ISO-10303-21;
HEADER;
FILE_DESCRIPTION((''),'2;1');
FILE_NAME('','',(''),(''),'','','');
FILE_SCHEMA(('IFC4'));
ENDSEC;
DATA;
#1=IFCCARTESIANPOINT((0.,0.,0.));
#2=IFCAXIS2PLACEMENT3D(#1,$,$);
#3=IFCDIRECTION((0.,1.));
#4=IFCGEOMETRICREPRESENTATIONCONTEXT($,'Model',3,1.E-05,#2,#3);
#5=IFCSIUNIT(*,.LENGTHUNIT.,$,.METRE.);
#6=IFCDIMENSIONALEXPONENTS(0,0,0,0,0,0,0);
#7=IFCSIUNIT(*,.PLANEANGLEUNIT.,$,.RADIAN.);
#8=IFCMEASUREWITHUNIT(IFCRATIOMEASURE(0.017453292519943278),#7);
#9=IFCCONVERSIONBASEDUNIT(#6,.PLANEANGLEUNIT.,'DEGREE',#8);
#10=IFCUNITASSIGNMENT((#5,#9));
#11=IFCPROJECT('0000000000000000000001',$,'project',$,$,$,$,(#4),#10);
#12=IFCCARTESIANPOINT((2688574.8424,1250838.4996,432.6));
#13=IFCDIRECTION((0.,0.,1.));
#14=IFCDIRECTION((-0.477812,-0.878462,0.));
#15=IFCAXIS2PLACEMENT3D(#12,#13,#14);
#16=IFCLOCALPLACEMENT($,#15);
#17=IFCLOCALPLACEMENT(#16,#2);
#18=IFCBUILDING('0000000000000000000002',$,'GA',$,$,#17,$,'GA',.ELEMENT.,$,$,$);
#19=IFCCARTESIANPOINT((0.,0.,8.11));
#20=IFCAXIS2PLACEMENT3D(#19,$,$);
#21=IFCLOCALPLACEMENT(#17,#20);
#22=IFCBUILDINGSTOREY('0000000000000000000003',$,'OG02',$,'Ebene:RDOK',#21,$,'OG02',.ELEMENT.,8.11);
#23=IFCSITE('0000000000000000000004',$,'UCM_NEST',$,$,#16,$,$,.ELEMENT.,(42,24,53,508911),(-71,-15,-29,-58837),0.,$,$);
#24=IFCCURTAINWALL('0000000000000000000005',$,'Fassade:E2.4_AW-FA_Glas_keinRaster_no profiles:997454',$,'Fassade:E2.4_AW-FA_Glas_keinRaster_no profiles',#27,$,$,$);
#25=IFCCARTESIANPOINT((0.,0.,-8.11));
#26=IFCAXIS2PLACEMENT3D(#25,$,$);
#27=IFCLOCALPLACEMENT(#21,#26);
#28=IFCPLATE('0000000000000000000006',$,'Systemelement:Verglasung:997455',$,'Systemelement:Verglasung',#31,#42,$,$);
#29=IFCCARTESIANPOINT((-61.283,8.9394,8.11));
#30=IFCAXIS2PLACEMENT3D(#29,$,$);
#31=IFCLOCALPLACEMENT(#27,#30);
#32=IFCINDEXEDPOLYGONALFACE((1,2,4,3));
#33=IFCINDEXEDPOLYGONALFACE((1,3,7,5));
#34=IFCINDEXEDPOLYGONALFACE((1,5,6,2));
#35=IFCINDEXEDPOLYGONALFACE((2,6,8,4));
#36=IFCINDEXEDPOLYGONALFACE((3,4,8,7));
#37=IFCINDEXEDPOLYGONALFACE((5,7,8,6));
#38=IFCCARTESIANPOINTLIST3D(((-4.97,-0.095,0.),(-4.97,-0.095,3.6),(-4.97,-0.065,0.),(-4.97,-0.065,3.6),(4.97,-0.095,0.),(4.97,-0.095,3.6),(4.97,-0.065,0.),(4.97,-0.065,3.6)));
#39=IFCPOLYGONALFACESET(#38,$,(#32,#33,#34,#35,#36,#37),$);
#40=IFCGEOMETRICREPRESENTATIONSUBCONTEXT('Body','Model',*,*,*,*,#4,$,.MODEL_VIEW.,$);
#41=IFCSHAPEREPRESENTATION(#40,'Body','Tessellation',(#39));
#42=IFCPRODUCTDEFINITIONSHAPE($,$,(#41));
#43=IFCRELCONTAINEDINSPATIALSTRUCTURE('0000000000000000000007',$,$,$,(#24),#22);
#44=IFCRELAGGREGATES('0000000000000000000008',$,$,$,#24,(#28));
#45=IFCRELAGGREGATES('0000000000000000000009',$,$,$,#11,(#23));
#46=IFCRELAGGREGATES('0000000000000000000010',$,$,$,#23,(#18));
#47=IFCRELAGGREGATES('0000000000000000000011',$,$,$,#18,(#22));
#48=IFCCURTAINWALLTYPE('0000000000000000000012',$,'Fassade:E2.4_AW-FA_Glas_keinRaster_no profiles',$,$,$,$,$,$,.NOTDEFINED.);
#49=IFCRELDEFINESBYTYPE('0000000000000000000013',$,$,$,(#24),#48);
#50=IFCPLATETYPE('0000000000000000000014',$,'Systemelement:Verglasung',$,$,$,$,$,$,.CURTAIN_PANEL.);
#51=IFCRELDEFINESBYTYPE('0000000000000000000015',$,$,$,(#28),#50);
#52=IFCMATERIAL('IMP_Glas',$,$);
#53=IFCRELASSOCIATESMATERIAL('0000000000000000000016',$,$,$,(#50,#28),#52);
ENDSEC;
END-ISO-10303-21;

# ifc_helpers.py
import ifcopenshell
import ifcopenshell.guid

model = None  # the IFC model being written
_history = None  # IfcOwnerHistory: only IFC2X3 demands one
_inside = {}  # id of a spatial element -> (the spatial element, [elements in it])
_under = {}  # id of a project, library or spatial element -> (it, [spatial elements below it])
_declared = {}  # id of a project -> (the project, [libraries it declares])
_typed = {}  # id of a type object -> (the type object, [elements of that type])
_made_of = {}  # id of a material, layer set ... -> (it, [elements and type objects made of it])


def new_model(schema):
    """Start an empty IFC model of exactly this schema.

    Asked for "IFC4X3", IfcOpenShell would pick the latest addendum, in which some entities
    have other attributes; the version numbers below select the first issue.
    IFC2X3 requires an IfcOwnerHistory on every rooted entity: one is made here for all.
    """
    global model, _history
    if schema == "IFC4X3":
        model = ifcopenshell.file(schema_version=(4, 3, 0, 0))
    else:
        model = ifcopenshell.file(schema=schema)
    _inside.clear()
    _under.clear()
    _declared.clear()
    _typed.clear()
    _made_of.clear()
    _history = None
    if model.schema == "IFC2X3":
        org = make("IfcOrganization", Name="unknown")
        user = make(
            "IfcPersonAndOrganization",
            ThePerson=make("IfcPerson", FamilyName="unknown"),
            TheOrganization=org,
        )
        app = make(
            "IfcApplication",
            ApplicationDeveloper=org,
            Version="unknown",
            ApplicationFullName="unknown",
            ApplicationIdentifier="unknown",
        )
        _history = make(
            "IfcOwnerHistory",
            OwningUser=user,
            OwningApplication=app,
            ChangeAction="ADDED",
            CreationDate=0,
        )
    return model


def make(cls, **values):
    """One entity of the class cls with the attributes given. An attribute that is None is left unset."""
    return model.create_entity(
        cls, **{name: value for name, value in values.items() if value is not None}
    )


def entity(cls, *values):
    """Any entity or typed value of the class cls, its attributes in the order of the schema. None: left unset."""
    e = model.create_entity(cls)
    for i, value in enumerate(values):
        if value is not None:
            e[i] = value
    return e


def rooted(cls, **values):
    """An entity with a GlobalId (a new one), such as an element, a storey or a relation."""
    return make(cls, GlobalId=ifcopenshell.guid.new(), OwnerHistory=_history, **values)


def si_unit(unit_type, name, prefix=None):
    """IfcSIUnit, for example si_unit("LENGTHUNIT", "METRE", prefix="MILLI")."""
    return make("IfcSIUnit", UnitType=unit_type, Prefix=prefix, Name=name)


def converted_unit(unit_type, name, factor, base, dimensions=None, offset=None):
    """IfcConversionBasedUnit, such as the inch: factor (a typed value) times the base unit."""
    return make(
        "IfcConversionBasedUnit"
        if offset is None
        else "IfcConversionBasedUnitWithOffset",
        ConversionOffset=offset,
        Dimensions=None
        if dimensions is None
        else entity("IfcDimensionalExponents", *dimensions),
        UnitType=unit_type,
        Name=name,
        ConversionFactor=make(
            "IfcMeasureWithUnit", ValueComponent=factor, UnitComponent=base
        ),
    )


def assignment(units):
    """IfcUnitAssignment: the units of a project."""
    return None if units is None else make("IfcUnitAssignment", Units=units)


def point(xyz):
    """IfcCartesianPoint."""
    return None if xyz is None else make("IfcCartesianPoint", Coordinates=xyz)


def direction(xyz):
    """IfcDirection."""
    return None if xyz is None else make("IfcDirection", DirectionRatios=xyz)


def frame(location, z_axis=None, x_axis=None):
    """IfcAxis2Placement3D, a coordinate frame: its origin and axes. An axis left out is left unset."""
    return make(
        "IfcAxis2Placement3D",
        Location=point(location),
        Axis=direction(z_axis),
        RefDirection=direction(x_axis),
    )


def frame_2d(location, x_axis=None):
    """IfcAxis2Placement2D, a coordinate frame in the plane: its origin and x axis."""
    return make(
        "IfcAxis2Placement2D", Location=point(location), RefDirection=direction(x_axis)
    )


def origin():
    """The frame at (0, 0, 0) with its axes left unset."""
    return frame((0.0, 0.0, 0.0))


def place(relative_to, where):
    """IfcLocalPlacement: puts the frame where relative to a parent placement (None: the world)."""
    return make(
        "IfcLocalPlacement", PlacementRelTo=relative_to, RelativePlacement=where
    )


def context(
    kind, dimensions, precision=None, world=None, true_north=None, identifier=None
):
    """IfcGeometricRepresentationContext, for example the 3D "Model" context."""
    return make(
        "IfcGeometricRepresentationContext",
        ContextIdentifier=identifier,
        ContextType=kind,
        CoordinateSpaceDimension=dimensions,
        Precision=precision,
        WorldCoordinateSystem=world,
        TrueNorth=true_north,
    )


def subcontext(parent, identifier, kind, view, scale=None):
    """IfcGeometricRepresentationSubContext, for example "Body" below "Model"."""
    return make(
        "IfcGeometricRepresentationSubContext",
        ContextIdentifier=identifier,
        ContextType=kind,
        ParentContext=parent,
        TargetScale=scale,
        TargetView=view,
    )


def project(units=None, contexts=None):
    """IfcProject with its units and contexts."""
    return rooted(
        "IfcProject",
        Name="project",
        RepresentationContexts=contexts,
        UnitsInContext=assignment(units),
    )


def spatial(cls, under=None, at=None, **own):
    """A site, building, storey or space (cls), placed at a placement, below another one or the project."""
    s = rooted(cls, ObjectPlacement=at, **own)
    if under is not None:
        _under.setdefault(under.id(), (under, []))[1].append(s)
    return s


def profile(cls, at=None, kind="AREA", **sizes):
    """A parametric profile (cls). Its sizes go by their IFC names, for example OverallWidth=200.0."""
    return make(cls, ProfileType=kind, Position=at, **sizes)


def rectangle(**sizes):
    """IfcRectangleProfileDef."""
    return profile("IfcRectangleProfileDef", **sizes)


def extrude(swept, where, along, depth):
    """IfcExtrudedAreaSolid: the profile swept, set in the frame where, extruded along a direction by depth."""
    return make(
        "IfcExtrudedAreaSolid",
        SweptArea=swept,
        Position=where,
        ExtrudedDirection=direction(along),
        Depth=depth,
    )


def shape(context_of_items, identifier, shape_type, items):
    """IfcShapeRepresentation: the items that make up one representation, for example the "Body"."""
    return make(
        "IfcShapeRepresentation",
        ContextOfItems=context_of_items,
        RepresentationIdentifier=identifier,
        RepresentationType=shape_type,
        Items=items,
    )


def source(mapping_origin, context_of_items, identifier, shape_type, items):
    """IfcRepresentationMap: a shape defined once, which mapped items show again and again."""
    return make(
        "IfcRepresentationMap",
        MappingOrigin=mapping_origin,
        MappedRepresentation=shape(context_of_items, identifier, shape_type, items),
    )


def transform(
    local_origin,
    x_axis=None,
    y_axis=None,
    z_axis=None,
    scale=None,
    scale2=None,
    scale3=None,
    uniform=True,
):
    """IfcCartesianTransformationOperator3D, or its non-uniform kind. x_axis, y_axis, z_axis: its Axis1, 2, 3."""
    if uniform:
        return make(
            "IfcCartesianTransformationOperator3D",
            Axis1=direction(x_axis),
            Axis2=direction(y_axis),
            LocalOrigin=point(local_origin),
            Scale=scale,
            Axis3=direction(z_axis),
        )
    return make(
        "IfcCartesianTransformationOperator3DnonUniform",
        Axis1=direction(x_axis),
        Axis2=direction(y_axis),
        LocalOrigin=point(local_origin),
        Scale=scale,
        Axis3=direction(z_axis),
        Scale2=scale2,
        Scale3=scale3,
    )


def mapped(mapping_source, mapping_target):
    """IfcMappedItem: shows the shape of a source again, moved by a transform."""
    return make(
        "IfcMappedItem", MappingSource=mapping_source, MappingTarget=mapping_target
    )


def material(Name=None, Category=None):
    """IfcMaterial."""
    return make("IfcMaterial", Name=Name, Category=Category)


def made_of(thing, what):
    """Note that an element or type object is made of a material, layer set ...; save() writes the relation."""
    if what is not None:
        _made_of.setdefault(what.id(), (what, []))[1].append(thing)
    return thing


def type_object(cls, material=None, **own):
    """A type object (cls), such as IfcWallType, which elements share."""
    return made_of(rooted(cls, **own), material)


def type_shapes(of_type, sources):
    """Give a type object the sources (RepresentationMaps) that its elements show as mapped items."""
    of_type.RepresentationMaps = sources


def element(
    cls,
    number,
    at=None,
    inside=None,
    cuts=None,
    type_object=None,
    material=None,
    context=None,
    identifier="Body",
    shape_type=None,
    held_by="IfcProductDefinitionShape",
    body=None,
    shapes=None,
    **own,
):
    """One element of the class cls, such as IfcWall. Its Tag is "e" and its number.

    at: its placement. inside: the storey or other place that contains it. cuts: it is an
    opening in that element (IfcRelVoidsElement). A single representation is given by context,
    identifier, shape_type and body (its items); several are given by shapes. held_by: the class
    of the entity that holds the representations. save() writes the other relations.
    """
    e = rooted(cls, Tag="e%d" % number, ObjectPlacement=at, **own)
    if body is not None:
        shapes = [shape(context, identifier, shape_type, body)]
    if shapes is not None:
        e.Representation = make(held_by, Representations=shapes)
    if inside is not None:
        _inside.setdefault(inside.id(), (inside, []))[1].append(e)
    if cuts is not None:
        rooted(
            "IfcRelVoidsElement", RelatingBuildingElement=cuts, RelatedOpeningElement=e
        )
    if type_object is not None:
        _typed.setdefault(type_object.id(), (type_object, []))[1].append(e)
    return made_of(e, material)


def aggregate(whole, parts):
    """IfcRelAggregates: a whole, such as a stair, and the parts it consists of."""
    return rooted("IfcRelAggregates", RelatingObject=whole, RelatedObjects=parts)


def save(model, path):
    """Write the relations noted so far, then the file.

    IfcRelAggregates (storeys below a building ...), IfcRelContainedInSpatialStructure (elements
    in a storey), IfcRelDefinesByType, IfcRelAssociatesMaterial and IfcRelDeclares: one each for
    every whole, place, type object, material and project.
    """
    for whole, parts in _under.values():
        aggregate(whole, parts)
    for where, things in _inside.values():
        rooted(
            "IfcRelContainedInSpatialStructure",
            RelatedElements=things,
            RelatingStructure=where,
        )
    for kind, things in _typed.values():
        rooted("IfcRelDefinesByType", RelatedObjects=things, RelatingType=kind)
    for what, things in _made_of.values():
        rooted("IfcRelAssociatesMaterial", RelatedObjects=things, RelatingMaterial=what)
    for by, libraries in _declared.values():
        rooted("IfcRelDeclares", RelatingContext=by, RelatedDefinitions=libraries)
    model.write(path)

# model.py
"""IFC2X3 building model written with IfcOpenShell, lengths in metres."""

from ifc_helpers import new_model, entity, si_unit, converted_unit, direction, frame, frame_2d, origin, place, context, subcontext, project, spatial, rectangle, extrude, source, transform, mapped, material, type_object, type_shapes, element, aggregate, save


model = new_model("IFC2X3")

# Units and contexts
model_context = context("Model", 3, precision=1e-05, world=origin(), true_north=direction((0.0, 1.0)))
body_context = subcontext(model_context, "Body", "Model", "MODEL_VIEW")
ifc_project = project(units=[si_unit("LENGTHUNIT", "METRE"), converted_unit("PLANEANGLEUNIT", "DEGREE", entity("IfcRatioMeasure", 0.017453292519943278), si_unit("PLANEANGLEUNIT", "RADIAN"), dimensions=[0, 0, 0, 0, 0, 0, 0])], contexts=[model_context])

# Site, building, storey
site_placement = place(None, frame((2688574.8424, 1250838.4996, 432.6), z_axis=(0.0, 0.0, 1.0), x_axis=(-0.477812, -0.878462, 0.0)))
site = spatial("IfcSite", under=ifc_project, at=site_placement, Name="UCM_NEST", CompositionType="ELEMENT", RefLatitude=(42, 24, 53, 508911), RefLongitude=(-71, -15, -29, -58837), RefElevation=0.0)
building_placement = place(site_placement, origin())
building = spatial("IfcBuilding", under=site, at=building_placement, Name="GA", LongName="GA", CompositionType="ELEMENT")
storey_placement = place(building_placement, frame((0.0, 0.0, 8.11)))
storey = spatial("IfcBuildingStorey", under=building, at=storey_placement, Name="OG02", ObjectType="Ebene:RDOK", LongName="OG02", CompositionType="ELEMENT", Elevation=8.11)

# Curtain wall, plate
curtain_wall_type = type_object("IfcCurtainWallType", Name="Fassade:E2.4_AW-FA_Glas_keinRaster_no profiles", PredefinedType="NOTDEFINED")
curtain_wall_placement = place(storey_placement, frame((0.0, 0.0, -8.11)))
curtain_wall = element("IfcCurtainWall", 1, at=curtain_wall_placement, inside=storey, type_object=curtain_wall_type, Name="Fassade:E2.4_AW-FA_Glas_keinRaster_no profiles:997454", ObjectType="Fassade:E2.4_AW-FA_Glas_keinRaster_no profiles")
ifc_material_1 = material(Name="IMP_Glas")
plate_type = type_object("IfcPlateType", Name="Systemelement:Verglasung", PredefinedType="CURTAIN_PANEL", material=ifc_material_1)
shared_shape = source(origin(), body_context, "Body", "SweptSolid", [
    extrude(rectangle(XDim=0.03, YDim=9.94, at=frame_2d((0.0, 0.0), x_axis=(1.0, 0.0))), frame((0.0, -0.08, 0.0), z_axis=(0.0, 0.0, 1.0), x_axis=(0.0, 1.0, 0.0)), (0.0, 0.0, 1.0), 3.6),
])
type_shapes(plate_type, [shared_shape])
plate_placement = place(curtain_wall_placement, frame((-61.283, 8.9394, 8.11)))
plate = element("IfcPlate", 2, at=plate_placement, type_object=plate_type, material=ifc_material_1, Name="Systemelement:Verglasung:997455", ObjectType="Systemelement:Verglasung", context=body_context, shape_type="MappedRepresentation", body=[
    mapped(shared_shape, transform((0.0, 0.0, 0.0), scale=1.0)),
])
aggregate(curtain_wall, [plate])

save(model, "model.ifc")
